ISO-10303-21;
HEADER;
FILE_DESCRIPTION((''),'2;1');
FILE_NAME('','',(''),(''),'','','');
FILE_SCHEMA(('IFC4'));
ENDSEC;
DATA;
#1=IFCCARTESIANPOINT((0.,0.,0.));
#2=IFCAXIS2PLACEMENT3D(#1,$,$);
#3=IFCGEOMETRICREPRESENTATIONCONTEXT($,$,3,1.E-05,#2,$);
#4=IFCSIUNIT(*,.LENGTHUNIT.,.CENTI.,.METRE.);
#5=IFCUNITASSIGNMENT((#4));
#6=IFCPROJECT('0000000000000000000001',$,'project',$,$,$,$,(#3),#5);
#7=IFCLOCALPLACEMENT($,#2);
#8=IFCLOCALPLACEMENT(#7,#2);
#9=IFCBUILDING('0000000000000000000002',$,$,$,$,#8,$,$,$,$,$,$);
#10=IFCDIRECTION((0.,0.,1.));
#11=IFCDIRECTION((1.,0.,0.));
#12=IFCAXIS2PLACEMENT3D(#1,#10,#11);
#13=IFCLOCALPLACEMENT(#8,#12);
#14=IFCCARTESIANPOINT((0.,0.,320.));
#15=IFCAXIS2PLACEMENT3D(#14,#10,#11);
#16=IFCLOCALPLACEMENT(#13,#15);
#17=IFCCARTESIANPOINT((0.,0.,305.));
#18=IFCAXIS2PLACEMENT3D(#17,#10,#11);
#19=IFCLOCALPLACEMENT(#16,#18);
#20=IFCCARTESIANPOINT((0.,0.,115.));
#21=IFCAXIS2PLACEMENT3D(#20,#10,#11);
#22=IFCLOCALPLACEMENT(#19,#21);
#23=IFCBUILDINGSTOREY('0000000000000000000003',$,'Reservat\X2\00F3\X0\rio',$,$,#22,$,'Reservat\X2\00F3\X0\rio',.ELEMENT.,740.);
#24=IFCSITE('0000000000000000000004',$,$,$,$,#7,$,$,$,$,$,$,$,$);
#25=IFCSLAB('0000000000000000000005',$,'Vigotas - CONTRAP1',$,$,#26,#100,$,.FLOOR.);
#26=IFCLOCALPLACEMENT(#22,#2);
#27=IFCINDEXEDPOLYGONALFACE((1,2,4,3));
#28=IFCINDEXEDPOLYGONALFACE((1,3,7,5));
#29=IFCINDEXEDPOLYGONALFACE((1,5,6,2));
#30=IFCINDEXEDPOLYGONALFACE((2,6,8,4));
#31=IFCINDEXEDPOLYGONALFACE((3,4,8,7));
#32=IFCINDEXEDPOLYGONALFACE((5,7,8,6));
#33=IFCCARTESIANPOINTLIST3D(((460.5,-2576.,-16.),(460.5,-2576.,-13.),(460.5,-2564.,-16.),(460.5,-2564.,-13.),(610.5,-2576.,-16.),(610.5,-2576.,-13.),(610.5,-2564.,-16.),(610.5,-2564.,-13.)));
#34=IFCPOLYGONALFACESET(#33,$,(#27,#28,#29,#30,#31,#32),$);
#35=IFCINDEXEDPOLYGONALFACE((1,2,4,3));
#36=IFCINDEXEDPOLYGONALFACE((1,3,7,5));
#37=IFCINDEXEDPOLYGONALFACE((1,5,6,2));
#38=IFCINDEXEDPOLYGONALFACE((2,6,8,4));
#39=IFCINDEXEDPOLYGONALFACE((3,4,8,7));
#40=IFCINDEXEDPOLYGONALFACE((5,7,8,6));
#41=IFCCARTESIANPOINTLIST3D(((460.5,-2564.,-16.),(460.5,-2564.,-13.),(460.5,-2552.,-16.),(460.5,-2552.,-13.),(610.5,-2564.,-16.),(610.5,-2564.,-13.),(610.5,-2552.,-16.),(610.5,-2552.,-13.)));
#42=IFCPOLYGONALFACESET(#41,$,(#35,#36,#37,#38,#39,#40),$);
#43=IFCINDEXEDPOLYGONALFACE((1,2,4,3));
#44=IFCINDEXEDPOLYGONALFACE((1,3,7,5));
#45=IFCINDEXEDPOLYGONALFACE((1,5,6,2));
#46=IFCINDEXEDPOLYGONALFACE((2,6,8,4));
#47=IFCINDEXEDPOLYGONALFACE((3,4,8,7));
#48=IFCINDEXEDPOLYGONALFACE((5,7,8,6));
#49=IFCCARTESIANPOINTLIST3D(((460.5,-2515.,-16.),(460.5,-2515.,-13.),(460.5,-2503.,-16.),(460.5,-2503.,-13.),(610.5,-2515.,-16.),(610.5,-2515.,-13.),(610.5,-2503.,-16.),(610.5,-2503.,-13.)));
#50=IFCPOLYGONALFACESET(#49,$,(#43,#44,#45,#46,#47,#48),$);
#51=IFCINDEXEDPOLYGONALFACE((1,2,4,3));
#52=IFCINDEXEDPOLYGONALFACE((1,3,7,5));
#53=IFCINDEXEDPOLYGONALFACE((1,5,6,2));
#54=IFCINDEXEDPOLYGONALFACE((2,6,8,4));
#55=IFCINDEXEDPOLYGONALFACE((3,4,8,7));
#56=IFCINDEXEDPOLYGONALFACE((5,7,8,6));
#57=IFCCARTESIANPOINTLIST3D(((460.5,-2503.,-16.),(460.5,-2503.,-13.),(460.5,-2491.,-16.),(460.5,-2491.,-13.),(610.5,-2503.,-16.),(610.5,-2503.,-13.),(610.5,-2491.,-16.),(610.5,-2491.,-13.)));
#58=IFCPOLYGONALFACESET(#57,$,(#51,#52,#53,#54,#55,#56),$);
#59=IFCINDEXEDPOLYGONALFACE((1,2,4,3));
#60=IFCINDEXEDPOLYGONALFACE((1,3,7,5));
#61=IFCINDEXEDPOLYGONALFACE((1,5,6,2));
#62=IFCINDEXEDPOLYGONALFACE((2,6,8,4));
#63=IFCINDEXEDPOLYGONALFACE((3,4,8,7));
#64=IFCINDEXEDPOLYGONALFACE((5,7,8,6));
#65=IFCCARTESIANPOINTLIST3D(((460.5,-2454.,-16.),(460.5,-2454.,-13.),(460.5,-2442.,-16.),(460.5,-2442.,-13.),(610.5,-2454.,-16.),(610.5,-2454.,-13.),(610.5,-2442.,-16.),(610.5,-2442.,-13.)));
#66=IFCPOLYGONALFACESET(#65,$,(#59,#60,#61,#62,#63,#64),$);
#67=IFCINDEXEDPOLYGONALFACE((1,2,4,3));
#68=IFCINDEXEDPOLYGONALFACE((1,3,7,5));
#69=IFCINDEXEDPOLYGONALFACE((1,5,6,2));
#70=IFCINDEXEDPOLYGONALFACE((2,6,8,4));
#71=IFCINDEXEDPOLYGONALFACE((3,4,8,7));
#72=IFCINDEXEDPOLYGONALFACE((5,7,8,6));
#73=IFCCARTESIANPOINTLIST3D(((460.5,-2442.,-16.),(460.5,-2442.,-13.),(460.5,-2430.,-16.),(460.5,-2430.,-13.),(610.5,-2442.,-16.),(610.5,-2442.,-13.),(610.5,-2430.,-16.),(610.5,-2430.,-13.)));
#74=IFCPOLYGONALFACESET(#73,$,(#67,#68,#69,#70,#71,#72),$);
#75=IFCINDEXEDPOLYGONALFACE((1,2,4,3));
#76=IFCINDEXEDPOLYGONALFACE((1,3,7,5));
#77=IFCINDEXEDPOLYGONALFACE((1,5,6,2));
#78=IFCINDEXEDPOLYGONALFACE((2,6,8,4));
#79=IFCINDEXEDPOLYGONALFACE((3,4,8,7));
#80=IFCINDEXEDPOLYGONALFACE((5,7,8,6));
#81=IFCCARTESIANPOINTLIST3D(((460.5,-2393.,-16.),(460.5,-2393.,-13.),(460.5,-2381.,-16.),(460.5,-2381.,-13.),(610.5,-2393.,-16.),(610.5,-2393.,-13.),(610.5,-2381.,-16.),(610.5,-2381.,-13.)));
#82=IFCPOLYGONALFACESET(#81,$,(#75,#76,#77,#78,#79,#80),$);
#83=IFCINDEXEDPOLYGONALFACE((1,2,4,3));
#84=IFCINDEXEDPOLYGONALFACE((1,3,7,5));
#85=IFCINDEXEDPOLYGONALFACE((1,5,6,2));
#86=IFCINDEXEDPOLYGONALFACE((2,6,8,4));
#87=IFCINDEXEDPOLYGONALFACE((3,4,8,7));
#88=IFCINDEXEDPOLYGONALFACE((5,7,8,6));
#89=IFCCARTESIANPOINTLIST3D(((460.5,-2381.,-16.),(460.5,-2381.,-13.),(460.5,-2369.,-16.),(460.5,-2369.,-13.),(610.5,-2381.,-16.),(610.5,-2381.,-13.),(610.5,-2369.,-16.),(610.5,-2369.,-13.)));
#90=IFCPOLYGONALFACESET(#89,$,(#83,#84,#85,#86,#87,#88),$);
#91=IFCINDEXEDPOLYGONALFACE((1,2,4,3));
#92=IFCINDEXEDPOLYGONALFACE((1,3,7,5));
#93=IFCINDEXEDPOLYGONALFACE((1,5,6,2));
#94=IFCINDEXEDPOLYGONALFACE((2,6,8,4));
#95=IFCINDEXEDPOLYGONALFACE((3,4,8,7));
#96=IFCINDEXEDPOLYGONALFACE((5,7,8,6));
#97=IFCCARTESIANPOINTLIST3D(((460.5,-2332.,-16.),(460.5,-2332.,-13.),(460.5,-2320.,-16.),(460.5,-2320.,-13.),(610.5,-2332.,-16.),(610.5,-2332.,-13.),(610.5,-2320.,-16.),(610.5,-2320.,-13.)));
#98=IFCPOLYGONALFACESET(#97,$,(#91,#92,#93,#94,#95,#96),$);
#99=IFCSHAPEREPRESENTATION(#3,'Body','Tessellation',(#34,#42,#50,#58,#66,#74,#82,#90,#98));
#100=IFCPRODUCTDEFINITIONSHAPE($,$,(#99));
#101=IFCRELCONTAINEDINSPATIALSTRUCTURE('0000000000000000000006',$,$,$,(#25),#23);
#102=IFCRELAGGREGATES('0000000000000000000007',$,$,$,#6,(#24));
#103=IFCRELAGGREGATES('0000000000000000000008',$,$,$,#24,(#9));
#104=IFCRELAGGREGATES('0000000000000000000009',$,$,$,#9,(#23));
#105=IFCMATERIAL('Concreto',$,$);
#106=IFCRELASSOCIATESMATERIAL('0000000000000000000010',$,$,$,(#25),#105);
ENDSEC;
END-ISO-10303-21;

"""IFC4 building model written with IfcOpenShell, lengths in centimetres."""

from ifc_helpers import new_model, si_unit, frame, origin, origin_with_axes, place, context, project, spatial, polyline, outline, extrude, material, element, save


model = new_model("IFC4")

# Units and contexts
context_of_model = context(None, 3, precision=1e-05, world=origin())
ifc_project = project(units=[si_unit("LENGTHUNIT", "METRE", prefix="CENTI")], contexts=[context_of_model])

# Site, building, storey
site_placement = place(None, origin())
site = spatial("IfcSite", under=ifc_project, at=site_placement)
building_placement = place(site_placement, origin())
building = spatial("IfcBuilding", under=site, at=building_placement)
placement_1 = place(building_placement, origin_with_axes())
placement_2 = place(placement_1, frame((0.0, 0.0, 320.0), z_axis=(0.0, 0.0, 1.0), x_axis=(1.0, 0.0, 0.0)))
placement_3 = place(placement_2, frame((0.0, 0.0, 305.0), z_axis=(0.0, 0.0, 1.0), x_axis=(1.0, 0.0, 0.0)))
storey_placement = place(placement_3, frame((0.0, 0.0, 115.0), z_axis=(0.0, 0.0, 1.0), x_axis=(1.0, 0.0, 0.0)))
storey = spatial("IfcBuildingStorey", under=building, at=storey_placement, Name="Reservatório", LongName="Reservatório", CompositionType="ELEMENT", Elevation=740.0)

# Shared definitions
ifc_material = material(Name="Concreto")

# Slab
slab_placement = place(storey_placement, frame((535.5, -2448.0, -13.0), z_axis=(0.0, 0.0, 1.0), x_axis=(1.0, 0.0, 0.0)))
element("IfcSlab", 1, at=slab_placement, inside=storey, material=ifc_material, Name="Vigotas - CONTRAP1", PredefinedType="FLOOR", context=context_of_model, shape_type="SolidModel", body=[
    extrude(outline(polyline([(6.0, 1.5), (-6.0, 1.5), (-6.0, -1.5), (6.0, -1.5), (6.0, 1.5), (6.0, 1.5)])), frame((-75.0, -122.0, -1.5), z_axis=(1.0, 0.0, 0.0), x_axis=(0.0, -1.0, 0.0)), (0.0, 0.0, 1.0), 150.0),
    extrude(outline(polyline([(6.0, 1.5), (-6.0, 1.5), (-6.0, -1.5), (6.0, -1.5), (6.0, 1.5), (6.0, 1.5)])), frame((-75.0, -110.0, -1.5), z_axis=(1.0, 0.0, 0.0), x_axis=(0.0, -1.0, 0.0)), (0.0, 0.0, 1.0), 150.0),
    extrude(outline(polyline([(6.0, 1.5), (-6.0, 1.5), (-6.0, -1.5), (6.0, -1.5), (6.0, 1.5), (6.0, 1.5)])), frame((-75.0, -61.0, -1.5), z_axis=(1.0, 0.0, 0.0), x_axis=(0.0, -1.0, 0.0)), (0.0, 0.0, 1.0), 150.0),
    extrude(outline(polyline([(6.0, 1.5), (-6.0, 1.5), (-6.0, -1.5), (6.0, -1.5), (6.0, 1.5), (6.0, 1.5)])), frame((-75.0, -49.0, -1.5), z_axis=(1.0, 0.0, 0.0), x_axis=(0.0, -1.0, 0.0)), (0.0, 0.0, 1.0), 150.0),
    extrude(outline(polyline([(6.0, 1.5), (-6.0, 1.5), (-6.0, -1.5), (6.0, -1.5), (6.0, 1.5), (6.0, 1.5)])), frame((-75.0, 0.0, -1.5), z_axis=(1.0, 0.0, 0.0), x_axis=(0.0, -1.0, 0.0)), (0.0, 0.0, 1.0), 150.0),
    extrude(outline(polyline([(6.0, 1.5), (-6.0, 1.5), (-6.0, -1.5), (6.0, -1.5), (6.0, 1.5), (6.0, 1.5)])), frame((-75.0, 12.0, -1.5), z_axis=(1.0, 0.0, 0.0), x_axis=(0.0, -1.0, 0.0)), (0.0, 0.0, 1.0), 150.0),
    extrude(outline(polyline([(6.0, 1.5), (-6.0, 1.5), (-6.0, -1.5), (6.0, -1.5), (6.0, 1.5), (6.0, 1.5)])), frame((-75.0, 61.0, -1.5), z_axis=(1.0, 0.0, 0.0), x_axis=(0.0, -1.0, 0.0)), (0.0, 0.0, 1.0), 150.0),
    extrude(outline(polyline([(6.0, 1.5), (-6.0, 1.5), (-6.0, -1.5), (6.0, -1.5), (6.0, 1.5), (6.0, 1.5)])), frame((-75.0, 73.0, -1.5), z_axis=(1.0, 0.0, 0.0), x_axis=(0.0, -1.0, 0.0)), (0.0, 0.0, 1.0), 150.0),
    extrude(outline(polyline([(6.0, 1.5), (-6.0, 1.5), (-6.0, -1.5), (6.0, -1.5), (6.0, 1.5), (6.0, 1.5)])), frame((-75.0, 122.0, -1.5), z_axis=(1.0, 0.0, 0.0), x_axis=(0.0, -1.0, 0.0)), (0.0, 0.0, 1.0), 150.0),
])

save(model, "model.ifc")
